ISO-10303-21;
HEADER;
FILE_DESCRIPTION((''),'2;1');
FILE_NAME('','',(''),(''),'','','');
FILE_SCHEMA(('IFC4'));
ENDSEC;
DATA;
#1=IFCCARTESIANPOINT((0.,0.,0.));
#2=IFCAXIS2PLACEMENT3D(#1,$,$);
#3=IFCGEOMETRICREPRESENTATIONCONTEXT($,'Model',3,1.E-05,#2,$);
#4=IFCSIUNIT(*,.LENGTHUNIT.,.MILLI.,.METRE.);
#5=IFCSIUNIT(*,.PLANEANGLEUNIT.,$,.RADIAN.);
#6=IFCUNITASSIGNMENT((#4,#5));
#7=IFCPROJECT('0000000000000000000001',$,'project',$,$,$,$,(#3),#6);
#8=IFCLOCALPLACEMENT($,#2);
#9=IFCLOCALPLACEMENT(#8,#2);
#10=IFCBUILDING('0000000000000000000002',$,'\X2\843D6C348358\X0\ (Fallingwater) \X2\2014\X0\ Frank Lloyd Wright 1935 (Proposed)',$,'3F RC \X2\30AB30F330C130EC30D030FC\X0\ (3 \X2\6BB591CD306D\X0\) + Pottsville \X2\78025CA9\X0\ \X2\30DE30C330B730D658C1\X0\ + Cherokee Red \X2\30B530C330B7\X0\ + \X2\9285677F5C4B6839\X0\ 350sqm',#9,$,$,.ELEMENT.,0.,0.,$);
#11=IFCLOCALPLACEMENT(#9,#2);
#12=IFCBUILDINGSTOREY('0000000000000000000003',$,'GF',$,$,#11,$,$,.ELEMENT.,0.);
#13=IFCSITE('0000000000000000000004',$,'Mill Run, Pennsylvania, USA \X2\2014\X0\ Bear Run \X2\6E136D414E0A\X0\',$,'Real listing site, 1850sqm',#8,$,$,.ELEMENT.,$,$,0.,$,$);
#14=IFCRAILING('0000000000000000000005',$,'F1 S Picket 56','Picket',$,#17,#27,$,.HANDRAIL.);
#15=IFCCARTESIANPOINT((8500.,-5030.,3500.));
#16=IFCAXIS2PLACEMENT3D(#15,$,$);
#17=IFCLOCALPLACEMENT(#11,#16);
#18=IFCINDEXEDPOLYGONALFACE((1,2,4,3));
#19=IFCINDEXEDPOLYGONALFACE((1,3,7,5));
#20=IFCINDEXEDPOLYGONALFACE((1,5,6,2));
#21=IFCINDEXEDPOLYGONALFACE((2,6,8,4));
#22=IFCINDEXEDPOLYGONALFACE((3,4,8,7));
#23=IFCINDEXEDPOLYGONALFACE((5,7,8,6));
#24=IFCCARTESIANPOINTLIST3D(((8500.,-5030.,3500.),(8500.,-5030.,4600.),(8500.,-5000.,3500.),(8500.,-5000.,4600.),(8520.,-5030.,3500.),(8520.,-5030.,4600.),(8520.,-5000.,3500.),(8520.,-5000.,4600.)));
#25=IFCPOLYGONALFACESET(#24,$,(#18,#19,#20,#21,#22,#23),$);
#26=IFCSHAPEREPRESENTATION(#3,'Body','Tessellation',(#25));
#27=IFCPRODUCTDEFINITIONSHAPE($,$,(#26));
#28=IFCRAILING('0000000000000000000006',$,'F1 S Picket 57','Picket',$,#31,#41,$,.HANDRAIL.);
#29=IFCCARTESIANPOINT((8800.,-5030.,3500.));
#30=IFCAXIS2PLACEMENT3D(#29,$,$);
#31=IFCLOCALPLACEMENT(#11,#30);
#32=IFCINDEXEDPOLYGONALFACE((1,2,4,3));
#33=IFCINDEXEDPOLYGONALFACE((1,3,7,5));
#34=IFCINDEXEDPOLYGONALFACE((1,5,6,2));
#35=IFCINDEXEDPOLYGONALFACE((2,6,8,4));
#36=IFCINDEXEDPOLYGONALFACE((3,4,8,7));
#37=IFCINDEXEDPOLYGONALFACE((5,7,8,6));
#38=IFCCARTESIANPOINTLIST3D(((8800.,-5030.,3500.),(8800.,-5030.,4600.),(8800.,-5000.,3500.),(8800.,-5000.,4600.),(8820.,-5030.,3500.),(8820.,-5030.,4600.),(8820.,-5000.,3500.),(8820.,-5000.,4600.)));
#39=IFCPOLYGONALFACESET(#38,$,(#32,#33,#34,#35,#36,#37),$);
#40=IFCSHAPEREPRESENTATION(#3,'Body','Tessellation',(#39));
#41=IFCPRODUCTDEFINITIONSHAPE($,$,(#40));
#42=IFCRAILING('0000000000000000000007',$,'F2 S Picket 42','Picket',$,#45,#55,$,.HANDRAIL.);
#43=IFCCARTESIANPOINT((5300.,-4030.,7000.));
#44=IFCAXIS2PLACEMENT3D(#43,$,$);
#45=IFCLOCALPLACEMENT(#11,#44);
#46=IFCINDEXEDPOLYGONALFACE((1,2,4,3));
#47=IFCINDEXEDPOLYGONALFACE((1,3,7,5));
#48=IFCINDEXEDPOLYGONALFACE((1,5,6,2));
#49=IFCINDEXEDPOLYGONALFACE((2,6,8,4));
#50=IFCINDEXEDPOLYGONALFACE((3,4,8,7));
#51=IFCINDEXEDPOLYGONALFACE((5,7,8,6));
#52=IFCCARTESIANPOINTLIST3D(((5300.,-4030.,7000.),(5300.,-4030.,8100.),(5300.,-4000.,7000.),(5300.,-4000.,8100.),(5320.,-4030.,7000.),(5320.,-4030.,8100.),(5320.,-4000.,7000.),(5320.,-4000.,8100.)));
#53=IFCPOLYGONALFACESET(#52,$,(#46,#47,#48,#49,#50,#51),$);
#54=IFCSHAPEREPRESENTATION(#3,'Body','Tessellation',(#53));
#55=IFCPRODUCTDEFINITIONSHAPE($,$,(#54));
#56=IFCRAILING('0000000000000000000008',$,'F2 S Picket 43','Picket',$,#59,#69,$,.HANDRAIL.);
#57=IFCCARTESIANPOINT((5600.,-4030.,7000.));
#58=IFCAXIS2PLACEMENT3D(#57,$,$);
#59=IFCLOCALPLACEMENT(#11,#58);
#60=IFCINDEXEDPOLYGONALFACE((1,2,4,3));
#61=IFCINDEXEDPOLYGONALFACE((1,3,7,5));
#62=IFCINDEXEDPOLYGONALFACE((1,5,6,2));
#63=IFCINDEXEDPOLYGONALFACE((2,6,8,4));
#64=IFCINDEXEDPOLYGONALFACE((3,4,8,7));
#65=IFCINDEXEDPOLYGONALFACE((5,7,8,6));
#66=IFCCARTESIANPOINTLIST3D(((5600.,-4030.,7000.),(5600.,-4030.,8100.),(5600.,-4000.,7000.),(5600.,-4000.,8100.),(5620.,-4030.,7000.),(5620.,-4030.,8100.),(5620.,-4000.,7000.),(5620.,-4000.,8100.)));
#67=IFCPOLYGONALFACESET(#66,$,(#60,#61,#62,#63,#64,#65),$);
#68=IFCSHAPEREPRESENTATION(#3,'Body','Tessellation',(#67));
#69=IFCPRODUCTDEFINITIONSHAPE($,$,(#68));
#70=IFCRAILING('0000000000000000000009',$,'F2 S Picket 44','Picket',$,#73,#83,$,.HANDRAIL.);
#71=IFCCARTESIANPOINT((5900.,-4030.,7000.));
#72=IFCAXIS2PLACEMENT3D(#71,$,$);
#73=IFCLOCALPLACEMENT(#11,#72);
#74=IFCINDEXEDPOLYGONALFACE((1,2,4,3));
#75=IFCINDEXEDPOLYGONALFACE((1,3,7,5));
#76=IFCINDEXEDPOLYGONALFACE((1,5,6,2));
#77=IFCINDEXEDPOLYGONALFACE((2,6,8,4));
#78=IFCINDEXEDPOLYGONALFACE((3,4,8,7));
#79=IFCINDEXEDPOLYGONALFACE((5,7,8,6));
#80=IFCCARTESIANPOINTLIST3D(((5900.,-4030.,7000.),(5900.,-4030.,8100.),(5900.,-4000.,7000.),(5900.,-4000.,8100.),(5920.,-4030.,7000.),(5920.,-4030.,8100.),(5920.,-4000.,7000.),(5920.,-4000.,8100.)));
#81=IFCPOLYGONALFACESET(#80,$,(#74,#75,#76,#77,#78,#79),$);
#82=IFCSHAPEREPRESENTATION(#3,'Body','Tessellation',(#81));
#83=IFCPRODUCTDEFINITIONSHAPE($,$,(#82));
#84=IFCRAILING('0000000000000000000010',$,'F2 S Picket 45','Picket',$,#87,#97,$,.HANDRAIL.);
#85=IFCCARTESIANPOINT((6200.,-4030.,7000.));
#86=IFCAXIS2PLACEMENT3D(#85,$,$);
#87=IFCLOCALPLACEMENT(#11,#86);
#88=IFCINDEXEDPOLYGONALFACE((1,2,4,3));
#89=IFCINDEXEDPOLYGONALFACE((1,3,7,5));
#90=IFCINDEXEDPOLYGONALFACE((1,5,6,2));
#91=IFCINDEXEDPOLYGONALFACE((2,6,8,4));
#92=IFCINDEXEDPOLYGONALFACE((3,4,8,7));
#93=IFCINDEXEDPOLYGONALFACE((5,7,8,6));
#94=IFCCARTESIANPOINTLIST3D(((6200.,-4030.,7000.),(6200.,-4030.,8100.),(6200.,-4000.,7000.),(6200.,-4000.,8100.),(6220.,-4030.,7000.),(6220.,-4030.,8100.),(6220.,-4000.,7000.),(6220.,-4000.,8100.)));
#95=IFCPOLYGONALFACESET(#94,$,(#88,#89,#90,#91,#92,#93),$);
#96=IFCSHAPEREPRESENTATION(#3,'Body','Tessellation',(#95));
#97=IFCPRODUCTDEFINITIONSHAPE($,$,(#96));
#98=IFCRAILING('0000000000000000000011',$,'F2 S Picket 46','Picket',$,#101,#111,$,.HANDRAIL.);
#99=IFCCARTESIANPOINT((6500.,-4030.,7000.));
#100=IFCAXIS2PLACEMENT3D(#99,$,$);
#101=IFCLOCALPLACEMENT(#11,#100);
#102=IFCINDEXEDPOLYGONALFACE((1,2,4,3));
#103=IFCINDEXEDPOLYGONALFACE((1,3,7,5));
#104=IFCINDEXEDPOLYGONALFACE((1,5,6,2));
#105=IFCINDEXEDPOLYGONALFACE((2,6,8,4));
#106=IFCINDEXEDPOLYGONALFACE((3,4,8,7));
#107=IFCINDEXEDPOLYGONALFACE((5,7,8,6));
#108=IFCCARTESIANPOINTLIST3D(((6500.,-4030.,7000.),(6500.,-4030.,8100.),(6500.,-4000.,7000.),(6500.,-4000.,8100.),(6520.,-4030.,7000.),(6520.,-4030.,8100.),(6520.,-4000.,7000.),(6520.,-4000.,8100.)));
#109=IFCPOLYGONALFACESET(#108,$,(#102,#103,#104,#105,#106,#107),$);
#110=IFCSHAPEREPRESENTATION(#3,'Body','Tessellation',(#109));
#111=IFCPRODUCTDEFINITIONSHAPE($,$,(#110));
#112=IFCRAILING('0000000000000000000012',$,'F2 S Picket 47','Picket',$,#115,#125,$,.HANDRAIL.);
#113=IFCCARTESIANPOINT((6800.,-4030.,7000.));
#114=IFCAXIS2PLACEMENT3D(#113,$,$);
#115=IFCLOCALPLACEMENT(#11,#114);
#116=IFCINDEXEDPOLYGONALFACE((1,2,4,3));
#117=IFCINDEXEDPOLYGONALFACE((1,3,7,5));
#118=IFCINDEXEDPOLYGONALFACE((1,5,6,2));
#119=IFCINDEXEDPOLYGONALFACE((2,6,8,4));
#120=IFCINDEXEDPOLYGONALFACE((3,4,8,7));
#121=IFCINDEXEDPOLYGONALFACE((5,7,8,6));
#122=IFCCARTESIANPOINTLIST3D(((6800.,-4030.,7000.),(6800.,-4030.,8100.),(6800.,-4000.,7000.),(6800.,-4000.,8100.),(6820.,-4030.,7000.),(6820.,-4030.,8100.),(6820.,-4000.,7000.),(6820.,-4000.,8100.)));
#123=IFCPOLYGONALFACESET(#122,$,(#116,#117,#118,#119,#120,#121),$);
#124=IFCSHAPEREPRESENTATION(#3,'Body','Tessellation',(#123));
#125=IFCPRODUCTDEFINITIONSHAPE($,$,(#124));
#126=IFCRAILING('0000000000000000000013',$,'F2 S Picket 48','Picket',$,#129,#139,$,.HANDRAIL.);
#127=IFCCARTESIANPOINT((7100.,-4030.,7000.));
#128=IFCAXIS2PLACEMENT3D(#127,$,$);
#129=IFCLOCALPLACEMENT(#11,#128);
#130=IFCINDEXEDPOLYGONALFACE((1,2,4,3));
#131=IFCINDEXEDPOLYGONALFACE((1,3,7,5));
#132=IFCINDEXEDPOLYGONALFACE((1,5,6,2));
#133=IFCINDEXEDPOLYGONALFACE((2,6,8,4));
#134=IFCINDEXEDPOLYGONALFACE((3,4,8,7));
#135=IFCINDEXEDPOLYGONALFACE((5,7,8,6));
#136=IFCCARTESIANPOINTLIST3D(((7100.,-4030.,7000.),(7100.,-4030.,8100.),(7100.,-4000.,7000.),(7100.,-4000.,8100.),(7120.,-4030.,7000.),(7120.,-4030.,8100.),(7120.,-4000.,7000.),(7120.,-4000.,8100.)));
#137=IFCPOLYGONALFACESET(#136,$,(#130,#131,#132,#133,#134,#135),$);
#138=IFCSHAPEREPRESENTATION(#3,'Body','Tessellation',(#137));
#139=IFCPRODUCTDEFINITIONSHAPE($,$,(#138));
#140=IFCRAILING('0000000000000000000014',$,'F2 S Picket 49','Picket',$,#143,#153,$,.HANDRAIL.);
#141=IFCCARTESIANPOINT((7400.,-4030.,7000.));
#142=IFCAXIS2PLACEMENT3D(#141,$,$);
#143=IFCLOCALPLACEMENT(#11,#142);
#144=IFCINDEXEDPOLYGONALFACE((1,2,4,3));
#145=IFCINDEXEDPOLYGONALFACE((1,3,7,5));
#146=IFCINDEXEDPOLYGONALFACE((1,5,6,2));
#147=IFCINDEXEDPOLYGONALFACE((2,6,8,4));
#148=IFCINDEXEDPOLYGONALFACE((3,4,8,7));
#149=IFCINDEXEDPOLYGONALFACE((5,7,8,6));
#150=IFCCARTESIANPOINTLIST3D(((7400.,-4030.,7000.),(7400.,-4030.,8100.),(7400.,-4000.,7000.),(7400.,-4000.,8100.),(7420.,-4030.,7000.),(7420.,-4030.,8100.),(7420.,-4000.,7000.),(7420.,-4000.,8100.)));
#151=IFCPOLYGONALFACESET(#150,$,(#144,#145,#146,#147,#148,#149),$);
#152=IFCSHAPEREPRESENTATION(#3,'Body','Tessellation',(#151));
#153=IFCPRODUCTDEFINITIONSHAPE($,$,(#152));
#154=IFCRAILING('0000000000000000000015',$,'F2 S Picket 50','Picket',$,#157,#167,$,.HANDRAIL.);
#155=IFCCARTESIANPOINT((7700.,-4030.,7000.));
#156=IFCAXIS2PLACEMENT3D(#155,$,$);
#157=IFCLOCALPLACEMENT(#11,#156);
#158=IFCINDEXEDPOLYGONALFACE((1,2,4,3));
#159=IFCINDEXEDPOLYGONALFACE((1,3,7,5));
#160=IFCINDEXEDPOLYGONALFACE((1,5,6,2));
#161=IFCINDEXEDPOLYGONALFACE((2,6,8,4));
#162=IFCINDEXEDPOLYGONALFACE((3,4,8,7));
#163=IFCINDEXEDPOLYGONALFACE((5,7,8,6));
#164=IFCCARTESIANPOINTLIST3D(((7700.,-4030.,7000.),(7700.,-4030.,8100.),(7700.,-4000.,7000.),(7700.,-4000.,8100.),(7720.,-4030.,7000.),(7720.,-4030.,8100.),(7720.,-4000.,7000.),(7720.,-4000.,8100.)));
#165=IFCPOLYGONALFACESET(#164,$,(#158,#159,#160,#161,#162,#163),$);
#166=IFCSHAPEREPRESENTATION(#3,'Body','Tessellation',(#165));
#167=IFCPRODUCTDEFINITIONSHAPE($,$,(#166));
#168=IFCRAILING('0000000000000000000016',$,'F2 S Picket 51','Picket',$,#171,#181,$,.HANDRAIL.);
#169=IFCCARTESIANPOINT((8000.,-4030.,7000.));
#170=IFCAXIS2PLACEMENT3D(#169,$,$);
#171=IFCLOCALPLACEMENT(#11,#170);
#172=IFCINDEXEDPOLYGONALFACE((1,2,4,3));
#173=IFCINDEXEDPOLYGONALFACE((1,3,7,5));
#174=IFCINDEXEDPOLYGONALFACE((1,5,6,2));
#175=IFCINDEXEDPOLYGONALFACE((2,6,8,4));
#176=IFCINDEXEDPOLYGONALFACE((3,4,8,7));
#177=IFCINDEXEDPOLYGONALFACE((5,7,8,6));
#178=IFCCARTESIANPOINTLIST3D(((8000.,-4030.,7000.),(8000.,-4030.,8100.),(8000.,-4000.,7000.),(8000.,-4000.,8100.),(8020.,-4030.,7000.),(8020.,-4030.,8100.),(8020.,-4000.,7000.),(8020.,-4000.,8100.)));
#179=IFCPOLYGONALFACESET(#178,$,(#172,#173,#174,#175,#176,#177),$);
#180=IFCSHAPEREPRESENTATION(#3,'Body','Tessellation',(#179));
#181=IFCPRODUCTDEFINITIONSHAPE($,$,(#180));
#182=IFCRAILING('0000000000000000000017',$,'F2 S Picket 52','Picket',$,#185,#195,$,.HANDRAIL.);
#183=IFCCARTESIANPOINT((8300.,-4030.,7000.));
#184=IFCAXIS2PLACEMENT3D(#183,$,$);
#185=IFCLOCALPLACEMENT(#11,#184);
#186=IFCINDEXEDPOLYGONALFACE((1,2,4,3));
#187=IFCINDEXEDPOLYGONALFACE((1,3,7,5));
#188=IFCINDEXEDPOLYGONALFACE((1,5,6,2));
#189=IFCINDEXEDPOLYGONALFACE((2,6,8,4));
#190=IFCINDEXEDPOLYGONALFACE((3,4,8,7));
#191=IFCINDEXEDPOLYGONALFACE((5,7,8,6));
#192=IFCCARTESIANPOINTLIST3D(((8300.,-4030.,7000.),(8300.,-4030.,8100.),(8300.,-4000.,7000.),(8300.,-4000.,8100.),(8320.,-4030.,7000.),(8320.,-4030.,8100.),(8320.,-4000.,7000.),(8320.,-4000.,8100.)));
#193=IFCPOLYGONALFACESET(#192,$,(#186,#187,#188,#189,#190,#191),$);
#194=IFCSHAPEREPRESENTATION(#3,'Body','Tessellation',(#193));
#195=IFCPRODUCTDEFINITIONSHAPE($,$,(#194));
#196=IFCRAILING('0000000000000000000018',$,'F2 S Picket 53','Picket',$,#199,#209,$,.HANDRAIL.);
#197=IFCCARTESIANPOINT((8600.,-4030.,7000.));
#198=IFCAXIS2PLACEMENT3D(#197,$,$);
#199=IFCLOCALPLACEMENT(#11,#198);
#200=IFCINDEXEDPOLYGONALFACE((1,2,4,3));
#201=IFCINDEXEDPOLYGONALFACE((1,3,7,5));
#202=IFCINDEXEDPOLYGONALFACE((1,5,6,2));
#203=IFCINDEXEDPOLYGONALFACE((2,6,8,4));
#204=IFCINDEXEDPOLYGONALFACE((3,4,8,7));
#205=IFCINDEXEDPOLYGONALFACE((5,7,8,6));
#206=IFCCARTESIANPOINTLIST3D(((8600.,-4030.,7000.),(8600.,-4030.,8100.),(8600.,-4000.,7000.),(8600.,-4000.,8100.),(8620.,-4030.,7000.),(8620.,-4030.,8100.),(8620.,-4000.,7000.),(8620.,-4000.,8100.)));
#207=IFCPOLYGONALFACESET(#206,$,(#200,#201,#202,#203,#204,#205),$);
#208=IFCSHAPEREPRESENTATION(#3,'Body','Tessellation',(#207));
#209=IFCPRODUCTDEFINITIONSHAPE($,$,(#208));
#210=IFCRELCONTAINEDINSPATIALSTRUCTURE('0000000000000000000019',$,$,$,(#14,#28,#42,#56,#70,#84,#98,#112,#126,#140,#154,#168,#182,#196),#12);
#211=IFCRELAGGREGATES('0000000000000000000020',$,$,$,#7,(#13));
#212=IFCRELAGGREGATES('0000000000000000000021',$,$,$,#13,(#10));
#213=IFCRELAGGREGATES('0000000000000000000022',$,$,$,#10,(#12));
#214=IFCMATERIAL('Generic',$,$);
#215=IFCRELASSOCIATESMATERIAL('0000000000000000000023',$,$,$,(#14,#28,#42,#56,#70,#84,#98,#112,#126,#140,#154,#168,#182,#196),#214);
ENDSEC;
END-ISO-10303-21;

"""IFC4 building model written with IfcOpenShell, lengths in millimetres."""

from ifc_helpers import new_model, si_unit, frame, frame_2d, origin, place, context, project, spatial, rectangle, extrude, material, element, save


model = new_model("IFC4")

# Units and contexts
model_context = context("Model", 3, precision=1e-05, world=origin())
ifc_project = project(units=[si_unit("LENGTHUNIT", "METRE", prefix="MILLI"), si_unit("PLANEANGLEUNIT", "RADIAN")], contexts=[model_context])

# Site, building, storey
site_placement = place(None, origin())
site = spatial("IfcSite", under=ifc_project, at=site_placement, Name="Mill Run, Pennsylvania, USA — Bear Run 渓流上", ObjectType="Real listing site, 1850sqm", CompositionType="ELEMENT", RefElevation=0.0)
building_placement = place(site_placement, origin())
building = spatial("IfcBuilding", under=site, at=building_placement, Name="落水荘 (Fallingwater) — Frank Lloyd Wright 1935 (Proposed)", ObjectType="3F RC カンチレバー (3 段重ね) + Pottsville 砂岩 マッシブ壁 + Cherokee Red サッシ + 銅板屋根 350sqm", CompositionType="ELEMENT", ElevationOfRefHeight=0.0, ElevationOfTerrain=0.0)
storey_placement = place(building_placement, origin())
storey = spatial("IfcBuildingStorey", under=building, at=storey_placement, Name="GF", CompositionType="ELEMENT", Elevation=0.0)

# Railings
ifc_material_1 = material(Name="Generic")
railing_1_placement = place(storey_placement, frame((8500.0, -5030.0, 3500.0)))
element("IfcRailing", 1, at=railing_1_placement, inside=storey, material=ifc_material_1, Name="F1 S Picket 56", Description="Picket", PredefinedType="HANDRAIL", context=model_context, shape_type="SweptSolid", body=[
    extrude(rectangle(XDim=20.0, YDim=30.0, at=frame_2d((10.0, 15.0))), frame((8500.0, -5030.0, 3500.0)), (0.0, 0.0, 1.0), 1100.0),
])
railing_2_placement = place(storey_placement, frame((8800.0, -5030.0, 3500.0)))
element("IfcRailing", 2, at=railing_2_placement, inside=storey, material=ifc_material_1, Name="F1 S Picket 57", Description="Picket", PredefinedType="HANDRAIL", context=model_context, shape_type="SweptSolid", body=[
    extrude(rectangle(XDim=20.0, YDim=30.0, at=frame_2d((10.0, 15.0))), frame((8800.0, -5030.0, 3500.0)), (0.0, 0.0, 1.0), 1100.0),
])
railing_3_placement = place(storey_placement, frame((5300.0, -4030.0, 7000.0)))
element("IfcRailing", 3, at=railing_3_placement, inside=storey, material=ifc_material_1, Name="F2 S Picket 42", Description="Picket", PredefinedType="HANDRAIL", context=model_context, shape_type="SweptSolid", body=[
    extrude(rectangle(XDim=20.0, YDim=30.0, at=frame_2d((10.0, 15.0))), frame((5300.0, -4030.0, 7000.0)), (0.0, 0.0, 1.0), 1100.0),
])
railing_4_placement = place(storey_placement, frame((5600.0, -4030.0, 7000.0)))
element("IfcRailing", 4, at=railing_4_placement, inside=storey, material=ifc_material_1, Name="F2 S Picket 43", Description="Picket", PredefinedType="HANDRAIL", context=model_context, shape_type="SweptSolid", body=[
    extrude(rectangle(XDim=20.0, YDim=30.0, at=frame_2d((10.0, 15.0))), frame((5600.0, -4030.0, 7000.0)), (0.0, 0.0, 1.0), 1100.0),
])
railing_5_placement = place(storey_placement, frame((5900.0, -4030.0, 7000.0)))
element("IfcRailing", 5, at=railing_5_placement, inside=storey, material=ifc_material_1, Name="F2 S Picket 44", Description="Picket", PredefinedType="HANDRAIL", context=model_context, shape_type="SweptSolid", body=[
    extrude(rectangle(XDim=20.0, YDim=30.0, at=frame_2d((10.0, 15.0))), frame((5900.0, -4030.0, 7000.0)), (0.0, 0.0, 1.0), 1100.0),
])
railing_6_placement = place(storey_placement, frame((6200.0, -4030.0, 7000.0)))
element("IfcRailing", 6, at=railing_6_placement, inside=storey, material=ifc_material_1, Name="F2 S Picket 45", Description="Picket", PredefinedType="HANDRAIL", context=model_context, shape_type="SweptSolid", body=[
    extrude(rectangle(XDim=20.0, YDim=30.0, at=frame_2d((10.0, 15.0))), frame((6200.0, -4030.0, 7000.0)), (0.0, 0.0, 1.0), 1100.0),
])
railing_7_placement = place(storey_placement, frame((6500.0, -4030.0, 7000.0)))
element("IfcRailing", 7, at=railing_7_placement, inside=storey, material=ifc_material_1, Name="F2 S Picket 46", Description="Picket", PredefinedType="HANDRAIL", context=model_context, shape_type="SweptSolid", body=[
    extrude(rectangle(XDim=20.0, YDim=30.0, at=frame_2d((10.0, 15.0))), frame((6500.0, -4030.0, 7000.0)), (0.0, 0.0, 1.0), 1100.0),
])
railing_8_placement = place(storey_placement, frame((6800.0, -4030.0, 7000.0)))
element("IfcRailing", 8, at=railing_8_placement, inside=storey, material=ifc_material_1, Name="F2 S Picket 47", Description="Picket", PredefinedType="HANDRAIL", context=model_context, shape_type="SweptSolid", body=[
    extrude(rectangle(XDim=20.0, YDim=30.0, at=frame_2d((10.0, 15.0))), frame((6800.0, -4030.0, 7000.0)), (0.0, 0.0, 1.0), 1100.0),
])
railing_9_placement = place(storey_placement, frame((7100.0, -4030.0, 7000.0)))
element("IfcRailing", 9, at=railing_9_placement, inside=storey, material=ifc_material_1, Name="F2 S Picket 48", Description="Picket", PredefinedType="HANDRAIL", context=model_context, shape_type="SweptSolid", body=[
    extrude(rectangle(XDim=20.0, YDim=30.0, at=frame_2d((10.0, 15.0))), frame((7100.0, -4030.0, 7000.0)), (0.0, 0.0, 1.0), 1100.0),
])
railing_10_placement = place(storey_placement, frame((7400.0, -4030.0, 7000.0)))
element("IfcRailing", 10, at=railing_10_placement, inside=storey, material=ifc_material_1, Name="F2 S Picket 49", Description="Picket", PredefinedType="HANDRAIL", context=model_context, shape_type="SweptSolid", body=[
    extrude(rectangle(XDim=20.0, YDim=30.0, at=frame_2d((10.0, 15.0))), frame((7400.0, -4030.0, 7000.0)), (0.0, 0.0, 1.0), 1100.0),
])
railing_11_placement = place(storey_placement, frame((7700.0, -4030.0, 7000.0)))
element("IfcRailing", 11, at=railing_11_placement, inside=storey, material=ifc_material_1, Name="F2 S Picket 50", Description="Picket", PredefinedType="HANDRAIL", context=model_context, shape_type="SweptSolid", body=[
    extrude(rectangle(XDim=20.0, YDim=30.0, at=frame_2d((10.0, 15.0))), frame((7700.0, -4030.0, 7000.0)), (0.0, 0.0, 1.0), 1100.0),
])
railing_12_placement = place(storey_placement, frame((8000.0, -4030.0, 7000.0)))
element("IfcRailing", 12, at=railing_12_placement, inside=storey, material=ifc_material_1, Name="F2 S Picket 51", Description="Picket", PredefinedType="HANDRAIL", context=model_context, shape_type="SweptSolid", body=[
    extrude(rectangle(XDim=20.0, YDim=30.0, at=frame_2d((10.0, 15.0))), frame((8000.0, -4030.0, 7000.0)), (0.0, 0.0, 1.0), 1100.0),
])
railing_13_placement = place(storey_placement, frame((8300.0, -4030.0, 7000.0)))
element("IfcRailing", 13, at=railing_13_placement, inside=storey, material=ifc_material_1, Name="F2 S Picket 52", Description="Picket", PredefinedType="HANDRAIL", context=model_context, shape_type="SweptSolid", body=[
    extrude(rectangle(XDim=20.0, YDim=30.0, at=frame_2d((10.0, 15.0))), frame((8300.0, -4030.0, 7000.0)), (0.0, 0.0, 1.0), 1100.0),
])
railing_14_placement = place(storey_placement, frame((8600.0, -4030.0, 7000.0)))
element("IfcRailing", 14, at=railing_14_placement, inside=storey, material=ifc_material_1, Name="F2 S Picket 53", Description="Picket", PredefinedType="HANDRAIL", context=model_context, shape_type="SweptSolid", body=[
    extrude(rectangle(XDim=20.0, YDim=30.0, at=frame_2d((10.0, 15.0))), frame((8600.0, -4030.0, 7000.0)), (0.0, 0.0, 1.0), 1100.0),
])

save(model, "model.ifc")
